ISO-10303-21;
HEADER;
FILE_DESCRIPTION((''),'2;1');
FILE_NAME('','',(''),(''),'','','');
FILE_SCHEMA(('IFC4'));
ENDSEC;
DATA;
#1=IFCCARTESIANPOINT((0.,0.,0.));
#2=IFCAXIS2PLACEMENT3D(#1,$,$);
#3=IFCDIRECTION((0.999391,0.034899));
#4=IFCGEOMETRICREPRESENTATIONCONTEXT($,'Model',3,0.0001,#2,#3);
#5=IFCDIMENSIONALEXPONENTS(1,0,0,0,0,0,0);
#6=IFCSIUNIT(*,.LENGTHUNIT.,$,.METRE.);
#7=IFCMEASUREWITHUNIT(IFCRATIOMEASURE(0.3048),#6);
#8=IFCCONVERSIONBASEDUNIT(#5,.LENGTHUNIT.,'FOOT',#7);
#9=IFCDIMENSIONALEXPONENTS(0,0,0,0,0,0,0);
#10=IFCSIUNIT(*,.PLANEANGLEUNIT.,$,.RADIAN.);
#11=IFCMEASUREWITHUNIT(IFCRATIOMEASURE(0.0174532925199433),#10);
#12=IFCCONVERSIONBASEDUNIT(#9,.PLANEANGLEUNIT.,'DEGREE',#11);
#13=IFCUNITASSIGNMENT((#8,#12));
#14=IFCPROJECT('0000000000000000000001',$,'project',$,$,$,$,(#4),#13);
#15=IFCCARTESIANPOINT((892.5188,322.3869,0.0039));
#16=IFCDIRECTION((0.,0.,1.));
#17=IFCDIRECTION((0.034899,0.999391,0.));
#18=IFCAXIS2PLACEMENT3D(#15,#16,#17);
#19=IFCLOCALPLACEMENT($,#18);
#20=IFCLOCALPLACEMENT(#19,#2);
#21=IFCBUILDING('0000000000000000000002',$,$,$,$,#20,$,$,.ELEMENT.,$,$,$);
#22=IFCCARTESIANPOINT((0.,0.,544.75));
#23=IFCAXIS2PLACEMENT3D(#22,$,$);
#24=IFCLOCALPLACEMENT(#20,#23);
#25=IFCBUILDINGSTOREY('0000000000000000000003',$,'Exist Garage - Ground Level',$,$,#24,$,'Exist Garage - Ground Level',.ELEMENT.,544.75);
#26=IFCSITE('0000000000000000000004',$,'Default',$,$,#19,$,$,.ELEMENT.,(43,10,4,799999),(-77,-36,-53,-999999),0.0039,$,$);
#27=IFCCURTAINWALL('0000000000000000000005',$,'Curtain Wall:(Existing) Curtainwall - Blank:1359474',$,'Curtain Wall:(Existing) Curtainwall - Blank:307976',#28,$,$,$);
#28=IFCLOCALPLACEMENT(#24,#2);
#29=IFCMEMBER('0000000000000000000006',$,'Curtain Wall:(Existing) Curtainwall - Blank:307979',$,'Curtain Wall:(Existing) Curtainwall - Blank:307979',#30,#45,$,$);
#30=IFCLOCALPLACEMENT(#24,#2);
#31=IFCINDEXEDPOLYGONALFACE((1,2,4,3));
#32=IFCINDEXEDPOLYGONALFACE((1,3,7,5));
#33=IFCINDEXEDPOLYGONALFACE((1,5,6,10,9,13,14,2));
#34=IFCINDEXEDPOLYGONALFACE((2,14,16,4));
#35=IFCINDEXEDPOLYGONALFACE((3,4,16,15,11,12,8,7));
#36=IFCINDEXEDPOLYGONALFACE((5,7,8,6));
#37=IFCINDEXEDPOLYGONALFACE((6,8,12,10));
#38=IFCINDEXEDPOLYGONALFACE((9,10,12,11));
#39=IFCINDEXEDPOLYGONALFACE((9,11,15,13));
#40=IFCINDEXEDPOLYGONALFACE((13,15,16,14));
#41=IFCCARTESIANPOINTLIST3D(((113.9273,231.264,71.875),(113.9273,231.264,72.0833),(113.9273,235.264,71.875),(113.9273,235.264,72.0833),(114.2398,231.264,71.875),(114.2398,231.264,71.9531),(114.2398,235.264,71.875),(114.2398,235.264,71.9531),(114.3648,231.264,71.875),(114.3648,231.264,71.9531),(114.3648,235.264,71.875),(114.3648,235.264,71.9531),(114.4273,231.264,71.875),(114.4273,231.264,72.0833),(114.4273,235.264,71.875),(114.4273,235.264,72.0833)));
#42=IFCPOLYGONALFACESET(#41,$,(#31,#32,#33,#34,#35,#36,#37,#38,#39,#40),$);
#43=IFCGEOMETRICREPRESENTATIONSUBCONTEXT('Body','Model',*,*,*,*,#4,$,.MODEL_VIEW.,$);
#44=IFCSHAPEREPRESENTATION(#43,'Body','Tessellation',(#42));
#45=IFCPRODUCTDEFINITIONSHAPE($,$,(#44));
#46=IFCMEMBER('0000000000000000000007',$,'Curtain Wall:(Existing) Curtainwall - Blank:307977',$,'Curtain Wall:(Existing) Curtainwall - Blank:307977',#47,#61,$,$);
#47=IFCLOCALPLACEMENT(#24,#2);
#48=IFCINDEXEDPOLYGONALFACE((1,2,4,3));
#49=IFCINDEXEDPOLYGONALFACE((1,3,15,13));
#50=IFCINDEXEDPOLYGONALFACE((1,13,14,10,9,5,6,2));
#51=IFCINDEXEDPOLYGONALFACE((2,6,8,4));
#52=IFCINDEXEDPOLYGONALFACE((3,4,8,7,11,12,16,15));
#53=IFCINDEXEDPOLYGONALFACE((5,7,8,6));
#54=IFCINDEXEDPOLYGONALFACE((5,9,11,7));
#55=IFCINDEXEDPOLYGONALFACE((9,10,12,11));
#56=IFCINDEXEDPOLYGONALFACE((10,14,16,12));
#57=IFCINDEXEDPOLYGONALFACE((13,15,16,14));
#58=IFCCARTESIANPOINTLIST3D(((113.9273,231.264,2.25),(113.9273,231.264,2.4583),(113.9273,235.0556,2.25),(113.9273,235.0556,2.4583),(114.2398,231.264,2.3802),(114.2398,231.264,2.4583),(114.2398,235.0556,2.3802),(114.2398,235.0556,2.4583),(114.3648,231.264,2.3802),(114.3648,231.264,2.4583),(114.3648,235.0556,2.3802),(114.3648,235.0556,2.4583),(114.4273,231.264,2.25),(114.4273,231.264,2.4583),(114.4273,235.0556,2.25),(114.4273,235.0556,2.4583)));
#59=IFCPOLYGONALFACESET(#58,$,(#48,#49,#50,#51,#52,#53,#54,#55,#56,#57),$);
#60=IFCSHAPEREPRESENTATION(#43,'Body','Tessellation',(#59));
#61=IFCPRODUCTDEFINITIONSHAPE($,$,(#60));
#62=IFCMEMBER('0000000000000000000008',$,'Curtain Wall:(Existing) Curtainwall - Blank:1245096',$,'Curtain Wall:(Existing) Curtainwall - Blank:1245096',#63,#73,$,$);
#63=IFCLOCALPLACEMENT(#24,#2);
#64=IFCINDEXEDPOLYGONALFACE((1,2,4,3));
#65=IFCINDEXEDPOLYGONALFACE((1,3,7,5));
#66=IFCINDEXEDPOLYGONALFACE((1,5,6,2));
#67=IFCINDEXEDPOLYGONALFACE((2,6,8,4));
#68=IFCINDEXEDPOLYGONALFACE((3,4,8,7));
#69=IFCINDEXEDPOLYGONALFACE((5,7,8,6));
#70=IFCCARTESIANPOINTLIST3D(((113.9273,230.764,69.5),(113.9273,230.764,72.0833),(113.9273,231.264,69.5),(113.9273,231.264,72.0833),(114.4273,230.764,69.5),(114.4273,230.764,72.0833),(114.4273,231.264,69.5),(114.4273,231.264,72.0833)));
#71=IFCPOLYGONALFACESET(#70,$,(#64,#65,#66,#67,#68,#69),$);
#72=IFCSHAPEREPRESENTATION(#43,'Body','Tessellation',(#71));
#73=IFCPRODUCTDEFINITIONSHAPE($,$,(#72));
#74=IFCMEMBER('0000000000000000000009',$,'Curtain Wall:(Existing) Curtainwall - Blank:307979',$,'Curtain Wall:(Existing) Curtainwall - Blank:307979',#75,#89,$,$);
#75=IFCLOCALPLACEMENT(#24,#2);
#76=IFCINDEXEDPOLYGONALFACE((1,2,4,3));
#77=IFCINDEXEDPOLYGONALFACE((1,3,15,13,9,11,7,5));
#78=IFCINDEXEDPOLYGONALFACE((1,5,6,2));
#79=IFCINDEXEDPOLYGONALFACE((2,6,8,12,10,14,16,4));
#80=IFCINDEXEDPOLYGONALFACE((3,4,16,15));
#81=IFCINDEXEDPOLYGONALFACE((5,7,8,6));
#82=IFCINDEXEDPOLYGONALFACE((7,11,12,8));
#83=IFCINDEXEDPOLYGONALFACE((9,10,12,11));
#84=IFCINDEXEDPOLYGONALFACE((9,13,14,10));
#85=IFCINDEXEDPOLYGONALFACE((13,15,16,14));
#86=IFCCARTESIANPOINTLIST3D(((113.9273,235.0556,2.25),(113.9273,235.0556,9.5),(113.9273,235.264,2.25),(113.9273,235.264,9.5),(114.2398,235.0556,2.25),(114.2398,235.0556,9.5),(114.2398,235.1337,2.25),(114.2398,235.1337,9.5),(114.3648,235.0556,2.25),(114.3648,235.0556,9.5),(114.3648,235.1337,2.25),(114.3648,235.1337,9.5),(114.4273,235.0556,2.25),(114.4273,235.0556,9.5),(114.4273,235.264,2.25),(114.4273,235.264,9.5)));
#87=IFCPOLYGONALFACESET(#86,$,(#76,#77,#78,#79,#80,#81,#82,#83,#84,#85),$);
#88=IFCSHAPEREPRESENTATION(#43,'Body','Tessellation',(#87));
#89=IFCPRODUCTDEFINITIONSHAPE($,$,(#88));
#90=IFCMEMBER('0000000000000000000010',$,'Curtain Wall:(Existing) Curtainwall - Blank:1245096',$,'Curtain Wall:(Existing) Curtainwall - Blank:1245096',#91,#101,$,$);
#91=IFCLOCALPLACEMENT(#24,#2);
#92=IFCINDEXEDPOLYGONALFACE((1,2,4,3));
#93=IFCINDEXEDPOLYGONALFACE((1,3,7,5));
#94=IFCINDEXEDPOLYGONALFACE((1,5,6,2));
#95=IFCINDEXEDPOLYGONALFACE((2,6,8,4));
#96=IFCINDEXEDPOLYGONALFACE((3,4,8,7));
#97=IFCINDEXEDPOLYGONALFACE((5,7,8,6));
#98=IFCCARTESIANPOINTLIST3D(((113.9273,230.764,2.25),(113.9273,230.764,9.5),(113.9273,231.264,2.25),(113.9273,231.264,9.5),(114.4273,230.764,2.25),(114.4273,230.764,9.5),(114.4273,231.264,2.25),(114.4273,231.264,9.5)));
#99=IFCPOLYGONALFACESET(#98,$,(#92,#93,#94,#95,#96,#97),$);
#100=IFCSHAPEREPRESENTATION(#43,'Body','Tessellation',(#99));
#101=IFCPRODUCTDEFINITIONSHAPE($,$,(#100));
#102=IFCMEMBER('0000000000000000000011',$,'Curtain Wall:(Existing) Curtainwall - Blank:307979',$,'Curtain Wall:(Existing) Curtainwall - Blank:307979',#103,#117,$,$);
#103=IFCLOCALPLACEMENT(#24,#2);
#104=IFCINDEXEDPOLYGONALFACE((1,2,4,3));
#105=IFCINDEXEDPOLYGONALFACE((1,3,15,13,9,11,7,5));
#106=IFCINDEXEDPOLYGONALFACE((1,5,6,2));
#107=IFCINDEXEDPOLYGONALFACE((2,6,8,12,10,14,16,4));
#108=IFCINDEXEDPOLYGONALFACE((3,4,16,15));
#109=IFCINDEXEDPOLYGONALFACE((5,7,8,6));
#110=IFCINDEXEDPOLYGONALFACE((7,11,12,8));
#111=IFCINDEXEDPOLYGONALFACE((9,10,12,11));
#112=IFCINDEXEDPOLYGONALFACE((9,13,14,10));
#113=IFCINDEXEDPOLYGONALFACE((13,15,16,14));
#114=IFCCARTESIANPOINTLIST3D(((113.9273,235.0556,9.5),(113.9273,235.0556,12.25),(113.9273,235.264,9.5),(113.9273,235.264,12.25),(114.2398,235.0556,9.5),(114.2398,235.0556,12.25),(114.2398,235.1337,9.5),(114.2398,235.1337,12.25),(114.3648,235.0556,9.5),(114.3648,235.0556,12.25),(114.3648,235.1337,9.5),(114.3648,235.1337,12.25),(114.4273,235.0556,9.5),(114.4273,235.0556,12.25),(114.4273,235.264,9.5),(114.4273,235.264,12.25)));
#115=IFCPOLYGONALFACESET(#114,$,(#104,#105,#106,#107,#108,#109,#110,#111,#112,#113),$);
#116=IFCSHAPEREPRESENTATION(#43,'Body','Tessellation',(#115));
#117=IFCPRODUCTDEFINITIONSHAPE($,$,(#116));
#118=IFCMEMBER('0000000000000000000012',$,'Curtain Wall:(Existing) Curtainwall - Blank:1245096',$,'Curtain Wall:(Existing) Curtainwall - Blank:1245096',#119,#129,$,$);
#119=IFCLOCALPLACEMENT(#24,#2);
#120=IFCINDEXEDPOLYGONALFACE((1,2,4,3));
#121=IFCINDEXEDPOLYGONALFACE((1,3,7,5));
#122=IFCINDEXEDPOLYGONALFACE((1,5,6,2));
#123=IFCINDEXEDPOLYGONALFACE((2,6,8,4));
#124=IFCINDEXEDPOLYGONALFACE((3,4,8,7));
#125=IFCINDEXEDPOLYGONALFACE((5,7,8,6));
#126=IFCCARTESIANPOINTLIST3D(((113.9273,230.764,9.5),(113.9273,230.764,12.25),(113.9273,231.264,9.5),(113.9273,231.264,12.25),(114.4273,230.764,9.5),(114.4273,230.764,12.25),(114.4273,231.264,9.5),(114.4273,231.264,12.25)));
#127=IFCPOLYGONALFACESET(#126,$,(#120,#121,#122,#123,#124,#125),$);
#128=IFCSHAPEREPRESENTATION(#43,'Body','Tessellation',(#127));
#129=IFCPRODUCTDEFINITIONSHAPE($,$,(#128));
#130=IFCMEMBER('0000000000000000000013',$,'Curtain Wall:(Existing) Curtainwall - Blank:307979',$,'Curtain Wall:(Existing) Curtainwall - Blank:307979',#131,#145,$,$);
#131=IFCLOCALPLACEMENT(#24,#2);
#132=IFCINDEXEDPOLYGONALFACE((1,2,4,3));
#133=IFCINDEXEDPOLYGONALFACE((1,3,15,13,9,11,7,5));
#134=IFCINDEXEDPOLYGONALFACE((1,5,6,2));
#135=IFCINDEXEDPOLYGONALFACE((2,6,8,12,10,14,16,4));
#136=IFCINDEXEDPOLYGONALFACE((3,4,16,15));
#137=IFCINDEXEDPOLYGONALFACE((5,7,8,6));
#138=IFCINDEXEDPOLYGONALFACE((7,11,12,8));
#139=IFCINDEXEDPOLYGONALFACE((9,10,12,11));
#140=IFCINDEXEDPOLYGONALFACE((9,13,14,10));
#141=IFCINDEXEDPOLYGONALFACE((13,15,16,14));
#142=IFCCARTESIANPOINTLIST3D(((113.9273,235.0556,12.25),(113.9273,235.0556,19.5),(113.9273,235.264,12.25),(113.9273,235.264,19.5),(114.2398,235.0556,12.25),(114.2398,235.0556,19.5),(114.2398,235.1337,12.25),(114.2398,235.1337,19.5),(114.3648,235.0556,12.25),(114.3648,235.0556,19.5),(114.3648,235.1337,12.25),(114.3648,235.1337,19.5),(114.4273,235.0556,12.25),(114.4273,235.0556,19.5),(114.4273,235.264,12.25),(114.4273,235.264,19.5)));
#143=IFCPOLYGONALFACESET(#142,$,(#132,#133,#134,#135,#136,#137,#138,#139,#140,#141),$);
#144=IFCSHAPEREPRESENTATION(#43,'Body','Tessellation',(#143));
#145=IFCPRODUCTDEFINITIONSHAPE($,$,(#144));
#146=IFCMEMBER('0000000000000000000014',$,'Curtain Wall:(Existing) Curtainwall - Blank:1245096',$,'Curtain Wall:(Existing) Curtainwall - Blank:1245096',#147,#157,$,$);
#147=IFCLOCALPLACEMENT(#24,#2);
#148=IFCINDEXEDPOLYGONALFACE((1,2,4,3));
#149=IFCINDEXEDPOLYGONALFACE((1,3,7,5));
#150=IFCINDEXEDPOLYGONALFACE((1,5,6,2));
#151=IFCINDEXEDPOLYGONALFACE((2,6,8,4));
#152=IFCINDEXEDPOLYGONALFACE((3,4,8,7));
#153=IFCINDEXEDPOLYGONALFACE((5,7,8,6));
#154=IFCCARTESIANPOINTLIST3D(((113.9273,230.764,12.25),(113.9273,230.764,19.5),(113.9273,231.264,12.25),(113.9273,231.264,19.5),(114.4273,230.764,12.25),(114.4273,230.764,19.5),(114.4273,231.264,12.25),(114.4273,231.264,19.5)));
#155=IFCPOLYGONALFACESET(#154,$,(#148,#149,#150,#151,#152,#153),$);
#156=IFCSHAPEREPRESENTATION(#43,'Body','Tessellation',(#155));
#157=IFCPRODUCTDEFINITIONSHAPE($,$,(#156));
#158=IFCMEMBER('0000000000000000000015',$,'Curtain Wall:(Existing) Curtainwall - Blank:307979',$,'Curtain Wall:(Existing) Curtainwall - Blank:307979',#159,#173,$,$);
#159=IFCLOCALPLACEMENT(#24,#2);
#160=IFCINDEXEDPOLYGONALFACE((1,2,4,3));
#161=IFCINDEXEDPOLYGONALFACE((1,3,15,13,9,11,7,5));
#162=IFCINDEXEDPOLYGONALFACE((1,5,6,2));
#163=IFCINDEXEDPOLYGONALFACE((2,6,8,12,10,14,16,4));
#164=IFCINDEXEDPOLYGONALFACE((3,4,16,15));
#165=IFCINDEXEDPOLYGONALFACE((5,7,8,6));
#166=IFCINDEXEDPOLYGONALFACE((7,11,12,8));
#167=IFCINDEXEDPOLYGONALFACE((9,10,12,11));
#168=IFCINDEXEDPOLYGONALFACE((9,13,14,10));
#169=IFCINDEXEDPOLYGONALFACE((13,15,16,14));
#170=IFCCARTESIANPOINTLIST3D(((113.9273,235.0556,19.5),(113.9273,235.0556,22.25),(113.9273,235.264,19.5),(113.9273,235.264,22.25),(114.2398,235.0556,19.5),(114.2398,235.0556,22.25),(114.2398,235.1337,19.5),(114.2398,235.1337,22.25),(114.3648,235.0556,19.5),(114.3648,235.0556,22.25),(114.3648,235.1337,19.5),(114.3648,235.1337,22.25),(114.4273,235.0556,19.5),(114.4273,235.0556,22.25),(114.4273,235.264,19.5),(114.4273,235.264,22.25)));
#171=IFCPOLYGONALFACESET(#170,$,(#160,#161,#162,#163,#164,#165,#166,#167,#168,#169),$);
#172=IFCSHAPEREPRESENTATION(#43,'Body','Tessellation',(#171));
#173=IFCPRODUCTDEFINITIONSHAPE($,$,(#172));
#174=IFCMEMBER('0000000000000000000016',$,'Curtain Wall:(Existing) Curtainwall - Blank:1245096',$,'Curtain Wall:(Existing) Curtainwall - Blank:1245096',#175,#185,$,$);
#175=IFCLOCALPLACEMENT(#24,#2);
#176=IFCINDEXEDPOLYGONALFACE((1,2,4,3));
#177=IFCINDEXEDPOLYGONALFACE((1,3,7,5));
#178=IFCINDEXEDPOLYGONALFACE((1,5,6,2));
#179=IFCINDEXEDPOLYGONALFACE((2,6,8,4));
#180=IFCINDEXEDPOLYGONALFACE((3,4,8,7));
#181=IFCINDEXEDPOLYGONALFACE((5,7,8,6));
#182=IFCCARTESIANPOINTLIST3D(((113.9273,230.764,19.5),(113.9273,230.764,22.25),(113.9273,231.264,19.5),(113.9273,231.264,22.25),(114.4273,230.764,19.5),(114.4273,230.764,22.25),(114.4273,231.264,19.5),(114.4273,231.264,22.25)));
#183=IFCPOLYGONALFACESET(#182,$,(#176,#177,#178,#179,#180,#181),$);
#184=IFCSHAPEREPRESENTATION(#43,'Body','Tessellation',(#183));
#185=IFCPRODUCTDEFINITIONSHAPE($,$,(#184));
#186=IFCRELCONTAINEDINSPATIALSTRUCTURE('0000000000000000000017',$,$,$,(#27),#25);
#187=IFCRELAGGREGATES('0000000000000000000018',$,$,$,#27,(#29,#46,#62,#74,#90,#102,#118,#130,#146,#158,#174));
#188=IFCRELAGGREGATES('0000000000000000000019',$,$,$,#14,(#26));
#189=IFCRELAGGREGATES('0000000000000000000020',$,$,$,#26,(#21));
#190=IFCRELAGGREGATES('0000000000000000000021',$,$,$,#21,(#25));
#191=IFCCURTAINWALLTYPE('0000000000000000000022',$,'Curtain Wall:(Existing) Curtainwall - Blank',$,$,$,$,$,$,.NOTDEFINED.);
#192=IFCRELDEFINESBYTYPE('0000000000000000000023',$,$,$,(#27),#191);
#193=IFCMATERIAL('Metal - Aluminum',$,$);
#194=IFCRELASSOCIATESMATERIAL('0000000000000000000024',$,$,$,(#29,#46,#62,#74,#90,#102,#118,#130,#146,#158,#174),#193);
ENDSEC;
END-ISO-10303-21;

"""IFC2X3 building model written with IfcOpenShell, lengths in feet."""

from ifc_helpers import new_model, entity, si_unit, converted_unit, direction, frame, origin, origin_2d_with_axis, place, context, subcontext, project, spatial, polyline, rectangle, outline, extrude, material, type_object, element, aggregate, save


model = new_model("IFC2X3")

# Units and contexts
model_context = context("Model", 3, precision=0.0001, world=origin(), true_north=direction((0.999391, 0.034899)))
body_context = subcontext(model_context, "Body", "Model", "MODEL_VIEW")
ifc_project = project(units=[converted_unit("LENGTHUNIT", "FOOT", entity("IfcRatioMeasure", 0.3048), si_unit("LENGTHUNIT", "METRE"), dimensions=[1, 0, 0, 0, 0, 0, 0]), converted_unit("PLANEANGLEUNIT", "DEGREE", entity("IfcRatioMeasure", 0.0174532925199433), si_unit("PLANEANGLEUNIT", "RADIAN"), dimensions=[0, 0, 0, 0, 0, 0, 0])], contexts=[model_context])

# Site, building, storey
site_placement = place(None, frame((892.5188, 322.3869, 0.0039), z_axis=(0.0, 0.0, 1.0), x_axis=(0.034899, 0.999391, 0.0)))
site = spatial("IfcSite", under=ifc_project, at=site_placement, Name="Default", CompositionType="ELEMENT", RefLatitude=(43, 10, 4, 799999), RefLongitude=(-77, -36, -53, -999999), RefElevation=0.0039)
building_placement = place(site_placement, origin())
building = spatial("IfcBuilding", under=site, at=building_placement, CompositionType="ELEMENT")
storey_placement = place(building_placement, frame((0.0, 0.0, 544.75)))
storey = spatial("IfcBuildingStorey", under=building, at=storey_placement, Name="Exist Garage - Ground Level", LongName="Exist Garage - Ground Level", CompositionType="ELEMENT", Elevation=544.75)

# Curtain wall, members
curtain_wall_type = type_object("IfcCurtainWallType", Name="Curtain Wall:(Existing) Curtainwall - Blank", PredefinedType="NOTDEFINED")
ifc_material = material(Name="Metal - Aluminum")
curtain_wall_1_placement = place(storey_placement, frame((0.0, 0.0, -544.75)))
curtain_wall_1 = element("IfcCurtainWall", 1, at=curtain_wall_1_placement, inside=storey, type_object=curtain_wall_type, Name="Curtain Wall:(Existing) Curtainwall - Blank:1359474", ObjectType="Curtain Wall:(Existing) Curtainwall - Blank:307976")
member_1_placement = place(curtain_wall_1_placement, frame((0.0, 0.0, 544.75)))
member_1 = element("IfcMember", 2, at=member_1_placement, material=ifc_material, Name="Curtain Wall:(Existing) Curtainwall - Blank:307979", ObjectType="Curtain Wall:(Existing) Curtainwall - Blank:307979", context=body_context, shape_type="SweptSolid", body=[
    extrude(outline(polyline([(-0.1367, -0.3125), (0.0716, -0.3125), (0.0716, 0.0), (-0.0065, 0.0), (-0.0065, 0.125), (0.0716, 0.125), (0.0716, 0.1875), (-0.1367, 0.1875), (-0.1367, -0.3125)])), frame((114.2398, 235.264, 71.9466), z_axis=(0.0, -1.0, 0.0), x_axis=(0.0, 0.0, -1.0)), (0.0, 0.0, 1.0), 4.0),
])
member_2_placement = place(curtain_wall_1_placement, frame((0.0, 0.0, 544.75)))
member_2 = element("IfcMember", 3, at=member_2_placement, material=ifc_material, Name="Curtain Wall:(Existing) Curtainwall - Blank:307977", ObjectType="Curtain Wall:(Existing) Curtainwall - Blank:307977", context=body_context, shape_type="SweptSolid", body=[
    extrude(outline(polyline([(-0.0716, -0.1875), (0.1367, -0.1875), (0.1367, 0.3125), (-0.0716, 0.3125), (-0.0716, 0.0), (0.0065, 0.0), (0.0065, -0.125), (-0.0716, -0.125), (-0.0716, -0.1875)])), frame((114.2398, 231.264, 2.3867), z_axis=(0.0, 1.0, 0.0), x_axis=(0.0, 0.0, -1.0)), (0.0, 0.0, 1.0), 3.7917),
])
member_3_placement = place(curtain_wall_1_placement, frame((0.0, 0.0, 544.75)))
member_3 = element("IfcMember", 4, at=member_3_placement, material=ifc_material, Name="Curtain Wall:(Existing) Curtainwall - Blank:1245096", ObjectType="Curtain Wall:(Existing) Curtainwall - Blank:1245096", context=body_context, shape_type="SweptSolid", body=[
    extrude(rectangle(XDim=0.5, YDim=0.5, at=origin_2d_with_axis()), frame((114.1773, 231.014, 72.0833), z_axis=(0.0, 0.0, -1.0), x_axis=(-1.0, 0.0, 0.0)), (0.0, 0.0, 1.0), 2.5833),
])
member_4_placement = place(curtain_wall_1_placement, frame((0.0, 0.0, 544.75)))
member_4 = element("IfcMember", 5, at=member_4_placement, material=ifc_material, Name="Curtain Wall:(Existing) Curtainwall - Blank:307979", ObjectType="Curtain Wall:(Existing) Curtainwall - Blank:307979", context=body_context, shape_type="SweptSolid", body=[
    extrude(outline(polyline([(-0.1875, -0.1367), (0.3125, -0.1367), (0.3125, 0.0716), (0.0, 0.0716), (0.0, -0.0065), (-0.125, -0.0065), (-0.125, 0.0716), (-0.1875, 0.0716), (-0.1875, -0.1367)])), frame((114.2398, 235.1272, 2.25), z_axis=(0.0, 0.0, 1.0), x_axis=(-1.0, 0.0, 0.0)), (0.0, 0.0, 1.0), 7.25),
])
member_5_placement = place(curtain_wall_1_placement, frame((0.0, 0.0, 544.75)))
member_5 = element("IfcMember", 6, at=member_5_placement, material=ifc_material, Name="Curtain Wall:(Existing) Curtainwall - Blank:1245096", ObjectType="Curtain Wall:(Existing) Curtainwall - Blank:1245096", context=body_context, shape_type="SweptSolid", body=[
    extrude(rectangle(XDim=0.5, YDim=0.5, at=origin_2d_with_axis()), frame((114.1773, 231.014, 9.5), z_axis=(0.0, 0.0, -1.0), x_axis=(-1.0, 0.0, 0.0)), (0.0, 0.0, 1.0), 7.25),
])
member_6_placement = place(curtain_wall_1_placement, frame((0.0, 0.0, 544.75)))
member_6 = element("IfcMember", 7, at=member_6_placement, material=ifc_material, Name="Curtain Wall:(Existing) Curtainwall - Blank:307979", ObjectType="Curtain Wall:(Existing) Curtainwall - Blank:307979", context=body_context, shape_type="SweptSolid", body=[
    extrude(outline(polyline([(-0.1875, -0.1367), (0.3125, -0.1367), (0.3125, 0.0716), (0.0, 0.0716), (0.0, -0.0065), (-0.125, -0.0065), (-0.125, 0.0716), (-0.1875, 0.0716), (-0.1875, -0.1367)])), frame((114.2398, 235.1272, 9.5), z_axis=(0.0, 0.0, 1.0), x_axis=(-1.0, 0.0, 0.0)), (0.0, 0.0, 1.0), 2.75),
])
member_7_placement = place(curtain_wall_1_placement, frame((0.0, 0.0, 544.75)))
member_7 = element("IfcMember", 8, at=member_7_placement, material=ifc_material, Name="Curtain Wall:(Existing) Curtainwall - Blank:1245096", ObjectType="Curtain Wall:(Existing) Curtainwall - Blank:1245096", context=body_context, shape_type="SweptSolid", body=[
    extrude(rectangle(XDim=0.5, YDim=0.5, at=origin_2d_with_axis()), frame((114.1773, 231.014, 12.25), z_axis=(0.0, 0.0, -1.0), x_axis=(-1.0, 0.0, 0.0)), (0.0, 0.0, 1.0), 2.75),
])
member_8_placement = place(curtain_wall_1_placement, frame((0.0, 0.0, 544.75)))
member_8 = element("IfcMember", 9, at=member_8_placement, material=ifc_material, Name="Curtain Wall:(Existing) Curtainwall - Blank:307979", ObjectType="Curtain Wall:(Existing) Curtainwall - Blank:307979", context=body_context, shape_type="SweptSolid", body=[
    extrude(outline(polyline([(-0.1875, -0.1367), (0.3125, -0.1367), (0.3125, 0.0716), (0.0, 0.0716), (0.0, -0.0065), (-0.125, -0.0065), (-0.125, 0.0716), (-0.1875, 0.0716), (-0.1875, -0.1367)])), frame((114.2398, 235.1272, 12.25), z_axis=(0.0, 0.0, 1.0), x_axis=(-1.0, 0.0, 0.0)), (0.0, 0.0, 1.0), 7.25),
])
member_9_placement = place(curtain_wall_1_placement, frame((0.0, 0.0, 544.75)))
member_9 = element("IfcMember", 10, at=member_9_placement, material=ifc_material, Name="Curtain Wall:(Existing) Curtainwall - Blank:1245096", ObjectType="Curtain Wall:(Existing) Curtainwall - Blank:1245096", context=body_context, shape_type="SweptSolid", body=[
    extrude(rectangle(XDim=0.5, YDim=0.5, at=origin_2d_with_axis()), frame((114.1773, 231.014, 19.5), z_axis=(0.0, 0.0, -1.0), x_axis=(-1.0, 0.0, 0.0)), (0.0, 0.0, 1.0), 7.25),
])
member_10_placement = place(curtain_wall_1_placement, frame((0.0, 0.0, 544.75)))
member_10 = element("IfcMember", 11, at=member_10_placement, material=ifc_material, Name="Curtain Wall:(Existing) Curtainwall - Blank:307979", ObjectType="Curtain Wall:(Existing) Curtainwall - Blank:307979", context=body_context, shape_type="SweptSolid", body=[
    extrude(outline(polyline([(-0.1875, -0.1367), (0.3125, -0.1367), (0.3125, 0.0716), (0.0, 0.0716), (0.0, -0.0065), (-0.125, -0.0065), (-0.125, 0.0716), (-0.1875, 0.0716), (-0.1875, -0.1367)])), frame((114.2398, 235.1272, 19.5), z_axis=(0.0, 0.0, 1.0), x_axis=(-1.0, 0.0, 0.0)), (0.0, 0.0, 1.0), 2.75),
])
member_11_placement = place(curtain_wall_1_placement, frame((0.0, 0.0, 544.75)))
member_11 = element("IfcMember", 12, at=member_11_placement, material=ifc_material, Name="Curtain Wall:(Existing) Curtainwall - Blank:1245096", ObjectType="Curtain Wall:(Existing) Curtainwall - Blank:1245096", context=body_context, shape_type="SweptSolid", body=[
    extrude(rectangle(XDim=0.5, YDim=0.5, at=origin_2d_with_axis()), frame((114.1773, 231.014, 22.25), z_axis=(0.0, 0.0, -1.0), x_axis=(-1.0, 0.0, 0.0)), (0.0, 0.0, 1.0), 2.75),
])
aggregate(curtain_wall_1, [member_1, member_2, member_3, member_4, member_5, member_6, member_7, member_8, member_9, member_10, member_11])

save(model, "model.ifc")
